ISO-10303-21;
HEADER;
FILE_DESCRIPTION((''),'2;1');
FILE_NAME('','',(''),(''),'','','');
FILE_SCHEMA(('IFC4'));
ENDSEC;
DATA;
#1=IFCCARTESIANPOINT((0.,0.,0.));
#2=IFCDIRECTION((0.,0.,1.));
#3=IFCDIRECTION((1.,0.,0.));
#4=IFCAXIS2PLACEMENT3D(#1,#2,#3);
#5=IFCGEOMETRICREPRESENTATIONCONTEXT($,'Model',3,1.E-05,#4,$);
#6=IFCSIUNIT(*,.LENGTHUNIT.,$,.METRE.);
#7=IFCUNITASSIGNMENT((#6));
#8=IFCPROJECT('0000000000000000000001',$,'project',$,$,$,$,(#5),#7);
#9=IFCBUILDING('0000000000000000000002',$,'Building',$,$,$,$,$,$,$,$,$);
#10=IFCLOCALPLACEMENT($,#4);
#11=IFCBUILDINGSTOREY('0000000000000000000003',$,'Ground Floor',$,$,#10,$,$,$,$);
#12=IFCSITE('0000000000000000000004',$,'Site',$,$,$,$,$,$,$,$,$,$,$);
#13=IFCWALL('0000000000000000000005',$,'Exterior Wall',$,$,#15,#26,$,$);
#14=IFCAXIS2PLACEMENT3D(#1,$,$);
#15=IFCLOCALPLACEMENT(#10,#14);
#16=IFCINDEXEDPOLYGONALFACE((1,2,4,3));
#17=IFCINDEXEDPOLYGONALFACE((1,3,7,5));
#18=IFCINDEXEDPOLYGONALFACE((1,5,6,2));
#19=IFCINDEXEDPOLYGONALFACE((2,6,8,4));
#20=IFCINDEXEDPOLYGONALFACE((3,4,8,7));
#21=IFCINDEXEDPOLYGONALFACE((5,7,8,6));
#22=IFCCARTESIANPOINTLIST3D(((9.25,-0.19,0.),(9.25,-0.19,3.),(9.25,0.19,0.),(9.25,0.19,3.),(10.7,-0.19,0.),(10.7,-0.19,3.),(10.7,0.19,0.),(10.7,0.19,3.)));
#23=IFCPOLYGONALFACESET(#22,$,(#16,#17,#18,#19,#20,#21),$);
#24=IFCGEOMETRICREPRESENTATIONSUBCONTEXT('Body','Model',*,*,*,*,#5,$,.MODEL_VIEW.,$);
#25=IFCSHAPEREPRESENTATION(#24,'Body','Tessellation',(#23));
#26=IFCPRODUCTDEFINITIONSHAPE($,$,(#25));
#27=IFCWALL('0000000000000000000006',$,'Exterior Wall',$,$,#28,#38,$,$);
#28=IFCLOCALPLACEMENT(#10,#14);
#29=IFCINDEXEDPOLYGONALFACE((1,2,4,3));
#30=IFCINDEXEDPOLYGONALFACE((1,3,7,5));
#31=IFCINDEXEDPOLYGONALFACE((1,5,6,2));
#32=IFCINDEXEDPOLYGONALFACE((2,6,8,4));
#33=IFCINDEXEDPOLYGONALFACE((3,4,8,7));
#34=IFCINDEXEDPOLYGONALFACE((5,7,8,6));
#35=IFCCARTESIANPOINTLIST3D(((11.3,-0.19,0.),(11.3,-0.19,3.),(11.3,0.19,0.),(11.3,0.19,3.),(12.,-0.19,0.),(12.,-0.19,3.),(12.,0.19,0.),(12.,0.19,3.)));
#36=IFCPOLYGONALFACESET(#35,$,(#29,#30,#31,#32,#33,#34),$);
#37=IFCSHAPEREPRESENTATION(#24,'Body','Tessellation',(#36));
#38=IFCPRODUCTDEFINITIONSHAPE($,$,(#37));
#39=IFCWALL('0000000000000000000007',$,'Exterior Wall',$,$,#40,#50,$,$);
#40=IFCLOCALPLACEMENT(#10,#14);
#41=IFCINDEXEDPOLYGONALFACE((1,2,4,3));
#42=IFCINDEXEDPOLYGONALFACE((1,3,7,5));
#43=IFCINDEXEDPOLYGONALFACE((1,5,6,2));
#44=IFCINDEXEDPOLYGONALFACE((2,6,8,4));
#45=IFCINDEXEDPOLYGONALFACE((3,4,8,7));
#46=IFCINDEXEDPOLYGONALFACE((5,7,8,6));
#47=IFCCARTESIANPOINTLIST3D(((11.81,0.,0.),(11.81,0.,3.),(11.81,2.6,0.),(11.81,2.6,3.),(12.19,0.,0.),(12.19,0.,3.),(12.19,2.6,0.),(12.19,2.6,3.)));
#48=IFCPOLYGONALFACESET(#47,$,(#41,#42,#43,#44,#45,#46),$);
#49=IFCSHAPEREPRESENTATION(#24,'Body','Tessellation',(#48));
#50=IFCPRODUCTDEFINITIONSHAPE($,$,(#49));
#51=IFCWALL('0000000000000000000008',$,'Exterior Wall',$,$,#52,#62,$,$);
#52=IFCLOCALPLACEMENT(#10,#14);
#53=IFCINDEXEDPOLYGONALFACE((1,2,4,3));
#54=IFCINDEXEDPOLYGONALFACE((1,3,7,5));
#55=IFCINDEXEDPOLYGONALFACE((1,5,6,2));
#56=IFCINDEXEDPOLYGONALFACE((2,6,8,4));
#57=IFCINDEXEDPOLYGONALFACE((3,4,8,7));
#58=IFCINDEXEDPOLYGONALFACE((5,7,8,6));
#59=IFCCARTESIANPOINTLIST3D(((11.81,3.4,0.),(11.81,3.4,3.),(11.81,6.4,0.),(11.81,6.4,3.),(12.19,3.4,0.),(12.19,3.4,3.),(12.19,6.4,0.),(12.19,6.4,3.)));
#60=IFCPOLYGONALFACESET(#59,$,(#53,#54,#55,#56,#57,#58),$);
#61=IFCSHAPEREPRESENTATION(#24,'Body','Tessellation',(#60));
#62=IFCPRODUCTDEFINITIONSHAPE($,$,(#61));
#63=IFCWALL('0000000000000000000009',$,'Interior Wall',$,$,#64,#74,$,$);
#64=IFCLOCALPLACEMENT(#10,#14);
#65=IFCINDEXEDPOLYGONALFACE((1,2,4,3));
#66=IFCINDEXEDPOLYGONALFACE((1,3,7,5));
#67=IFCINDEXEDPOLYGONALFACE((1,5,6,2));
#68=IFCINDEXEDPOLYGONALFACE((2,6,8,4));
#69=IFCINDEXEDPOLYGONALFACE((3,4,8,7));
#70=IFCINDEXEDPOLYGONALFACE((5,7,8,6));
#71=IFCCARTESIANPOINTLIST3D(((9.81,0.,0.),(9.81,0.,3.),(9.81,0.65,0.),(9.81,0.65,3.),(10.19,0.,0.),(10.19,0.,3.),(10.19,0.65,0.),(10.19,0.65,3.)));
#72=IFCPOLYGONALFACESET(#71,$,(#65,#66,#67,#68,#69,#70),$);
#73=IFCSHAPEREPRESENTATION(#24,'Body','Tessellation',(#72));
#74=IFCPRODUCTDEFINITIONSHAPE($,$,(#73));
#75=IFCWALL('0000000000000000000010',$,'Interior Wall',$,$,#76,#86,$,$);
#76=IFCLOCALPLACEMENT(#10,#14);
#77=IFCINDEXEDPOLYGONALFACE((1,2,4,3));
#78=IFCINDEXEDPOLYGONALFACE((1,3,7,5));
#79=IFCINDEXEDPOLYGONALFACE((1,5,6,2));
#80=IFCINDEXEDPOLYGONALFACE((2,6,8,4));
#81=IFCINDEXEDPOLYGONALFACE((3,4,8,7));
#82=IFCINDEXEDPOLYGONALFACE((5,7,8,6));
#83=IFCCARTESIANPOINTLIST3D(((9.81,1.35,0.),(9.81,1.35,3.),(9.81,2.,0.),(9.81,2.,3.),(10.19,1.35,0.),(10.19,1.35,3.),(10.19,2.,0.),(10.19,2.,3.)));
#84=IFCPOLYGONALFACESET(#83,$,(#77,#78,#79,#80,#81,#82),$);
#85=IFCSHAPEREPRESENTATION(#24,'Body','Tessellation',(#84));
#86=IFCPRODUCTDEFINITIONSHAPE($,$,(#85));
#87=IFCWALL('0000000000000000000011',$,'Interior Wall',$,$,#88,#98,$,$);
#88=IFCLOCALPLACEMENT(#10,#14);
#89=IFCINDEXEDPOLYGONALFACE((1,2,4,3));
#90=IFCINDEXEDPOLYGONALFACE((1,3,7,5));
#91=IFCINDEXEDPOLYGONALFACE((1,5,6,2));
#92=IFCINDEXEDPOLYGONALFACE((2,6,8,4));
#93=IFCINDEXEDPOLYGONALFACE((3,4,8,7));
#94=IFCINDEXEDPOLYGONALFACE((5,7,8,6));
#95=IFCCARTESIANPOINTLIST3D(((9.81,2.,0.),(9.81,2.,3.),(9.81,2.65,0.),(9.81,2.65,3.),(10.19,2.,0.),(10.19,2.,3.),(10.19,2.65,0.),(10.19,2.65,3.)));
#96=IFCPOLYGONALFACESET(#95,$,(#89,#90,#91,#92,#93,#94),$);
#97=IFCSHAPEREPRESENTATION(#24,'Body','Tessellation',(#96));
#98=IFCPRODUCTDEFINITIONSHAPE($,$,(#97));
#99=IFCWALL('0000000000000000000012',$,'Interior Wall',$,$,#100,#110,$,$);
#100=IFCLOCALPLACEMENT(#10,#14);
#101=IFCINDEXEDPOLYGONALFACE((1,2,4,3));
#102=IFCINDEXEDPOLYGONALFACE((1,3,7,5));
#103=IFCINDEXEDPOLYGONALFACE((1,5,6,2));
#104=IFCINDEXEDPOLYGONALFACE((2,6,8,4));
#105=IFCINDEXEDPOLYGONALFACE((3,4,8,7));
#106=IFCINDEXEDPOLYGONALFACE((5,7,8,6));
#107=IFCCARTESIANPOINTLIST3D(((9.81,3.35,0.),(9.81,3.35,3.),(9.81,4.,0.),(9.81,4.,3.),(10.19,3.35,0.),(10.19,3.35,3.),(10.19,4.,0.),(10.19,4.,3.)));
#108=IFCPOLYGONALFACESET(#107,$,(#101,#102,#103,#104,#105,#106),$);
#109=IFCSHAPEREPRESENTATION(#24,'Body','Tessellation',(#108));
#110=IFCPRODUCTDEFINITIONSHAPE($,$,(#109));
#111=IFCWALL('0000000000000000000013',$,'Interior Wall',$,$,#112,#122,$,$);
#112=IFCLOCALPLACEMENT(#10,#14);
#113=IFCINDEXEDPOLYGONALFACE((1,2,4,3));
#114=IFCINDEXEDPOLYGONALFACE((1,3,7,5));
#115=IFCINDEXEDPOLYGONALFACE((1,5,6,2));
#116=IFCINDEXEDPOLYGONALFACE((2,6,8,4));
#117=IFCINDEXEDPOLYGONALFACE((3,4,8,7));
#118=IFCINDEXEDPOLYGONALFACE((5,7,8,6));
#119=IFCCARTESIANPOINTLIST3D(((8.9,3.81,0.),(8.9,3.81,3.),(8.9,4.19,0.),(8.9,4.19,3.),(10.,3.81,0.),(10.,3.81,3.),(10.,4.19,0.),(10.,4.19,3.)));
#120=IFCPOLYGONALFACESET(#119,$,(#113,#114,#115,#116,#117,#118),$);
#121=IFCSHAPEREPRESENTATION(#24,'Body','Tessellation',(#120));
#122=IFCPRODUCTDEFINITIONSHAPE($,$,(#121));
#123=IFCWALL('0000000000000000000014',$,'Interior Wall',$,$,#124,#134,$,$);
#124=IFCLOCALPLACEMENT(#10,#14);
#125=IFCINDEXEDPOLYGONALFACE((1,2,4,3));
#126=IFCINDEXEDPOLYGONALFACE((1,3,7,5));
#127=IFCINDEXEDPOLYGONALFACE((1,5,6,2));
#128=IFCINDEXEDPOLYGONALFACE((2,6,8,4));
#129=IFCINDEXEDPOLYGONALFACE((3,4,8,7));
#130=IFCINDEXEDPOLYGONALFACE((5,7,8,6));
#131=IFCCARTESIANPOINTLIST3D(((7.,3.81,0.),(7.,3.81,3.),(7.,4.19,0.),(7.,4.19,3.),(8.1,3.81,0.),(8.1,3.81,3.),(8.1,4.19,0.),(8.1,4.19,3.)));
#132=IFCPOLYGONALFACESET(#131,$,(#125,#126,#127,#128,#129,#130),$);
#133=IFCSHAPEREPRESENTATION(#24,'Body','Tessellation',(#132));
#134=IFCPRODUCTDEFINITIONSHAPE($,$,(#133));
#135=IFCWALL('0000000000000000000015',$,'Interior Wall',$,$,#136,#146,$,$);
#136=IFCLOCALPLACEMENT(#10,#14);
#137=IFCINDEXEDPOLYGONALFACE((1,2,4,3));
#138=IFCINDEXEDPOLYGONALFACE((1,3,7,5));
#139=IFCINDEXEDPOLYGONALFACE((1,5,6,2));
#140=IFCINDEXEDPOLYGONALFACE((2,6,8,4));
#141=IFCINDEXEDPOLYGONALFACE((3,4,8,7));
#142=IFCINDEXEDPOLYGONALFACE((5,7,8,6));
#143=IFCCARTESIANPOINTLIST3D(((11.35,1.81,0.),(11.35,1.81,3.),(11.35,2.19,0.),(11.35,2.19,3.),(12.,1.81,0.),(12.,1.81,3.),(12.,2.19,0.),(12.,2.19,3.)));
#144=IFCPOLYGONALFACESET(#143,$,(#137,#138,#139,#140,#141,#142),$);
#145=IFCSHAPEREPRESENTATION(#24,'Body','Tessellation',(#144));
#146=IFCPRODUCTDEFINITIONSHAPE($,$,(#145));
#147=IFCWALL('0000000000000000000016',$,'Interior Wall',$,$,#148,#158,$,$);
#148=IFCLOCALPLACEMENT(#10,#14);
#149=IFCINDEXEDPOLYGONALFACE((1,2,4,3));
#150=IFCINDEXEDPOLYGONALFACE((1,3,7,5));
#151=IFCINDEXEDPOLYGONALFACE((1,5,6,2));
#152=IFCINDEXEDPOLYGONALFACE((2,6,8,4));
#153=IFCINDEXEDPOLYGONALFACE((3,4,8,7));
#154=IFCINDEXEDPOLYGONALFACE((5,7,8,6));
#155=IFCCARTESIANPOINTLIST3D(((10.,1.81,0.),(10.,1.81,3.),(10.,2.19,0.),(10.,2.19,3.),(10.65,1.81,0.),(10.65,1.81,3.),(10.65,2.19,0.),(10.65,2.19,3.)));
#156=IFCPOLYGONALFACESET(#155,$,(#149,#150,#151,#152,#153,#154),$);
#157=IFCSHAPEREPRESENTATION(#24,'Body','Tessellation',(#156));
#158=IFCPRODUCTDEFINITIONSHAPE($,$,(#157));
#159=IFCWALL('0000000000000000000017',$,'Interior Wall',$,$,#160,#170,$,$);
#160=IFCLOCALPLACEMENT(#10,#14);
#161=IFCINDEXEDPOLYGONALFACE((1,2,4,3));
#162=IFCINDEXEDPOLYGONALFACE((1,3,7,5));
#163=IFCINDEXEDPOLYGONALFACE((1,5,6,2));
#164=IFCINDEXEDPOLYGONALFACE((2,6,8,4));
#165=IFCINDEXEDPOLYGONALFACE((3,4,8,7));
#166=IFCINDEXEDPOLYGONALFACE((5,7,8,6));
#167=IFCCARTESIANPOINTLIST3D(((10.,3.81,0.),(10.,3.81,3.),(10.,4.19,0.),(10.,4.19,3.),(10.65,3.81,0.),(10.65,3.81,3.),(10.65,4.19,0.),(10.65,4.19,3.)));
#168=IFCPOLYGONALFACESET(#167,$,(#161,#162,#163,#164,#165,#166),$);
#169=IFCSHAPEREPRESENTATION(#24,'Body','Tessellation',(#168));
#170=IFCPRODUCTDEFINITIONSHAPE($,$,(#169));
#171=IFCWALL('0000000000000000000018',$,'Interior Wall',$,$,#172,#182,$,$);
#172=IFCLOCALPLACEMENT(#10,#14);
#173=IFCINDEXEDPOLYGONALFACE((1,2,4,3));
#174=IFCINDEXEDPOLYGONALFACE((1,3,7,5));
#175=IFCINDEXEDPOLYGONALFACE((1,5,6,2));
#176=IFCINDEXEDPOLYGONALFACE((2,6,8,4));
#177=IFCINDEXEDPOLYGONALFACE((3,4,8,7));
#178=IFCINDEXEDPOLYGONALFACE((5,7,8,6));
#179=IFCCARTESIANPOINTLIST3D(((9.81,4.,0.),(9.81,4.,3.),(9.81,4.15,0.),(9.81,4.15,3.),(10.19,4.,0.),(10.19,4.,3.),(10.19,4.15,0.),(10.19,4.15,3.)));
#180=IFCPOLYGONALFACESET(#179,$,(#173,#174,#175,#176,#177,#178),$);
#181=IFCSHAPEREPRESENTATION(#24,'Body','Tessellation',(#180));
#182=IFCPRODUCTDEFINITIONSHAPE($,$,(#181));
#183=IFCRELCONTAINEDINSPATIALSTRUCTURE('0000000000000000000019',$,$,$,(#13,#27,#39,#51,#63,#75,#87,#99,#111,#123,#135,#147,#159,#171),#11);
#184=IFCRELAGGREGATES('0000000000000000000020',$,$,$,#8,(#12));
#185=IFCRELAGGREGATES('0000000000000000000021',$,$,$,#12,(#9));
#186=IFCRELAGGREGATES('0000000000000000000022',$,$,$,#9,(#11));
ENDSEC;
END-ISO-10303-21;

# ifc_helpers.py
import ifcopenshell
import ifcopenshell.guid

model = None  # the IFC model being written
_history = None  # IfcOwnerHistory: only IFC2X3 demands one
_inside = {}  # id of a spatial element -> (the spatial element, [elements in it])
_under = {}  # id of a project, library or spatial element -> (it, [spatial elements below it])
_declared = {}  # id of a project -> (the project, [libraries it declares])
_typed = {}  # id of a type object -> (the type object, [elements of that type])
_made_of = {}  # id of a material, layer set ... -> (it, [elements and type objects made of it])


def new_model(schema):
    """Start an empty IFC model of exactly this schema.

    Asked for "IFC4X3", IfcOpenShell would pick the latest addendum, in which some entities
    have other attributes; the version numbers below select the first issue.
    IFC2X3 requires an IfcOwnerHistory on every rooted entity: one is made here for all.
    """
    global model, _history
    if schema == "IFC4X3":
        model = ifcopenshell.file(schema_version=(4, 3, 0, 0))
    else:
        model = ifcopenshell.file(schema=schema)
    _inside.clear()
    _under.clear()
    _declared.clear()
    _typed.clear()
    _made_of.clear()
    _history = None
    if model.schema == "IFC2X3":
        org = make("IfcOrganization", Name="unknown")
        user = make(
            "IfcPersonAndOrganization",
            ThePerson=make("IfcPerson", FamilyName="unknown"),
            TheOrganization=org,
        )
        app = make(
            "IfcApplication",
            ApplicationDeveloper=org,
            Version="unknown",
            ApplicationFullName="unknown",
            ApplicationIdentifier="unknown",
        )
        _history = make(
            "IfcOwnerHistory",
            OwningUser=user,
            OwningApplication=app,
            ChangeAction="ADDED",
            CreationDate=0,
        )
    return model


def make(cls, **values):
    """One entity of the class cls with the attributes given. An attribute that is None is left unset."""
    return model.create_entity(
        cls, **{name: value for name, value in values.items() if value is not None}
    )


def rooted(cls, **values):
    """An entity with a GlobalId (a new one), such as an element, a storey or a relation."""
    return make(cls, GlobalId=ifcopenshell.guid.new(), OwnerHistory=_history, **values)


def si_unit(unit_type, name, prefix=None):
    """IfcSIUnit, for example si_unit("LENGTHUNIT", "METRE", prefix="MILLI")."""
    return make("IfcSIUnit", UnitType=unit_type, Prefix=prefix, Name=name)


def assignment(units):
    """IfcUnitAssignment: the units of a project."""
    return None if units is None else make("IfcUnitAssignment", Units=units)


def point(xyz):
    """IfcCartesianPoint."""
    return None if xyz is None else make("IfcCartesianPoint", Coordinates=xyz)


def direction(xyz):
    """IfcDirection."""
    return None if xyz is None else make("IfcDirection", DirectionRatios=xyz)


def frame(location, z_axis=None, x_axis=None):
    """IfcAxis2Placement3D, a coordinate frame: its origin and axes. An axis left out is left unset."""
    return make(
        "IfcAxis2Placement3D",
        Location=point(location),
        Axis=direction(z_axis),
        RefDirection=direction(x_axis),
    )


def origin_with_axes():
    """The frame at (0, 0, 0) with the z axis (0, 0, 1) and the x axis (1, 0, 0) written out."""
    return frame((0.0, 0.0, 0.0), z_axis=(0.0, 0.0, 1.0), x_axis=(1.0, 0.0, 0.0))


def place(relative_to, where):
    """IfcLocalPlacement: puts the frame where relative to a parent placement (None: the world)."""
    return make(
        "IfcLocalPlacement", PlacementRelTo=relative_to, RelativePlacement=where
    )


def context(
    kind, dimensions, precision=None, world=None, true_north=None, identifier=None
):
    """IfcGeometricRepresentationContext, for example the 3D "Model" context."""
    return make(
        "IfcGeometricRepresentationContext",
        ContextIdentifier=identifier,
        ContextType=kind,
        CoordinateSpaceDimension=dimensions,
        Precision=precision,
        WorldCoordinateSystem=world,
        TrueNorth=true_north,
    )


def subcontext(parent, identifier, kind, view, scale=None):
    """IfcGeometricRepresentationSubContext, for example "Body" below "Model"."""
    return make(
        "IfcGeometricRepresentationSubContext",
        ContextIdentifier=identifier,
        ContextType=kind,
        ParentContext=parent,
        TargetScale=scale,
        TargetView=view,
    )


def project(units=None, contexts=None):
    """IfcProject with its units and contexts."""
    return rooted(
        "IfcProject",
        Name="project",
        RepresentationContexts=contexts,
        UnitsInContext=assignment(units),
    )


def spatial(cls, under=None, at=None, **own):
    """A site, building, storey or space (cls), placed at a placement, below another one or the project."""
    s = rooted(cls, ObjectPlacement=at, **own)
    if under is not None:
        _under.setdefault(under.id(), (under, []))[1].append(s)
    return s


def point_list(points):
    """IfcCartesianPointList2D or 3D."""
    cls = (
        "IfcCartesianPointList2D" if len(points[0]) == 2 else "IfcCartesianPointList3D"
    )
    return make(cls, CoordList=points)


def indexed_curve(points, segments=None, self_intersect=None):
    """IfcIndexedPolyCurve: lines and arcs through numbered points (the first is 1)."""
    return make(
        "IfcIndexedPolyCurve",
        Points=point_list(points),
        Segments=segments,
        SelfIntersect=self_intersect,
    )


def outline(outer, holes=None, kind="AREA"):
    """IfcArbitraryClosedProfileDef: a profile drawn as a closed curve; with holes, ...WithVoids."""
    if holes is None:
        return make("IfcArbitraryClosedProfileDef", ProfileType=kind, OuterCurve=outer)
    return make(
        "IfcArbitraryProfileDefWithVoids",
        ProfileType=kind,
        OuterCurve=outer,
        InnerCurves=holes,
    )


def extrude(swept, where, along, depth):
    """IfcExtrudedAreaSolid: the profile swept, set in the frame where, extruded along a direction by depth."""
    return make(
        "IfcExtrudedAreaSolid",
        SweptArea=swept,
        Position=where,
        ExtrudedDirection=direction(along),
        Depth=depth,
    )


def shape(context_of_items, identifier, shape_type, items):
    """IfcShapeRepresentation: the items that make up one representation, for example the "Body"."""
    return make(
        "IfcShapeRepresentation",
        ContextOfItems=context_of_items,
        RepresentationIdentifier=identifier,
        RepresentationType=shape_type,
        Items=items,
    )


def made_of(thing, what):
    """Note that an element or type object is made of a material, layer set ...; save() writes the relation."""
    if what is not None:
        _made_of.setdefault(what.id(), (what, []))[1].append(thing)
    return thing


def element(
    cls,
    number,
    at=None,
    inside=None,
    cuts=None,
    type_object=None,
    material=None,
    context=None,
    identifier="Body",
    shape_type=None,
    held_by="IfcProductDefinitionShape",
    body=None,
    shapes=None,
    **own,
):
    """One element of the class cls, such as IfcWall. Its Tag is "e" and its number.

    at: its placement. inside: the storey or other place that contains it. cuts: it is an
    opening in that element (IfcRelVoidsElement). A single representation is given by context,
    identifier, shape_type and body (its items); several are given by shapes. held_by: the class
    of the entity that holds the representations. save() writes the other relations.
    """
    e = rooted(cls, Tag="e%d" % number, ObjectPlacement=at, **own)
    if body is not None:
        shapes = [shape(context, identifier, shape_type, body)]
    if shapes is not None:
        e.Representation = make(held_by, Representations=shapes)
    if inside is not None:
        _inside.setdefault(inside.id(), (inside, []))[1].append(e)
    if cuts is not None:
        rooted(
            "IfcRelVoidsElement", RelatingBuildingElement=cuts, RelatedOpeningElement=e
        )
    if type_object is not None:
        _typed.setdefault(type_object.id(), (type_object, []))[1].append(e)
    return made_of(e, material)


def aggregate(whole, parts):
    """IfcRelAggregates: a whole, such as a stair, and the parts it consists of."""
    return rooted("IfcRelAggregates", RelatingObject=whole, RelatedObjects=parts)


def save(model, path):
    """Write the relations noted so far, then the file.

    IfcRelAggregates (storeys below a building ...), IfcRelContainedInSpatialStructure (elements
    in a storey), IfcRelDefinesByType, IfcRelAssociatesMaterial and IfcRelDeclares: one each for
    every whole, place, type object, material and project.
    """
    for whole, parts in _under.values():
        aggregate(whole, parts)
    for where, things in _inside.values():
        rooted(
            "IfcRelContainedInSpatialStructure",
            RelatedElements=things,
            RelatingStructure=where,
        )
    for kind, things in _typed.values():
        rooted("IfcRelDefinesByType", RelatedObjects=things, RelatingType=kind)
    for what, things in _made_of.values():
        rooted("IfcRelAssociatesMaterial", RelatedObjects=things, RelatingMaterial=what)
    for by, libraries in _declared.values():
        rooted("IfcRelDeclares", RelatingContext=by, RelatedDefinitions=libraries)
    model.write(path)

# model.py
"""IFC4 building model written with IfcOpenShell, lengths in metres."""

from ifc_helpers import new_model, si_unit, frame, origin_with_axes, place, context, subcontext, project, spatial, indexed_curve, outline, extrude, element, save


model = new_model("IFC4")

# Units and contexts
model_context = context("Model", 3, precision=1e-05, world=origin_with_axes())
body_context = subcontext(model_context, "Body", "Model", "MODEL_VIEW")
ifc_project = project(units=[si_unit("LENGTHUNIT", "METRE")], contexts=[model_context])

# Site, building, storey
site = spatial("IfcSite", under=ifc_project, Name="Site")
building = spatial("IfcBuilding", under=site, Name="Building")
storey_placement = place(None, origin_with_axes())
storey = spatial("IfcBuildingStorey", under=building, at=storey_placement, Name="Ground Floor")

# Walls
wall_1_placement = place(storey_placement, frame((9.25, 0.0, 0.0), z_axis=(0.0, 0.0, 1.0), x_axis=(1.0, 0.0, 0.0)))
element("IfcWall", 1, at=wall_1_placement, inside=storey, Name="Exterior Wall", context=body_context, shape_type="SweptSolid", body=[
    extrude(outline(indexed_curve([(0.0, 0.0), (0.0, 0.38), (1.45, 0.38), (1.45, 0.0), (0.0, 0.0)], self_intersect=False)), frame((0.0, -0.19, 0.0), z_axis=(0.0, 0.0, 1.0), x_axis=(1.0, 0.0, 0.0)), (0.0, 0.0, 1.0), 3.0),
])
wall_2_placement = place(storey_placement, frame((11.3, 0.0, 0.0), z_axis=(0.0, 0.0, 1.0), x_axis=(1.0, 0.0, 0.0)))
element("IfcWall", 2, at=wall_2_placement, inside=storey, Name="Exterior Wall", context=body_context, shape_type="SweptSolid", body=[
    extrude(outline(indexed_curve([(0.0, 0.0), (0.0, 0.38), (0.7, 0.38), (0.7, 0.0), (0.0, 0.0)], self_intersect=False)), frame((0.0, -0.19, 0.0), z_axis=(0.0, 0.0, 1.0), x_axis=(1.0, 0.0, 0.0)), (0.0, 0.0, 1.0), 3.0),
])
wall_3_placement = place(storey_placement, frame((12.0, 0.0, 0.0), z_axis=(0.0, 0.0, 1.0), x_axis=(0.0, 1.0, 0.0)))
element("IfcWall", 3, at=wall_3_placement, inside=storey, Name="Exterior Wall", context=body_context, shape_type="SweptSolid", body=[
    extrude(outline(indexed_curve([(0.0, 0.0), (0.0, 0.38), (2.6, 0.38), (2.6, 0.0), (0.0, 0.0)], self_intersect=False)), frame((0.0, -0.19, 0.0), z_axis=(0.0, 0.0, 1.0), x_axis=(1.0, 0.0, 0.0)), (0.0, 0.0, 1.0), 3.0),
])
wall_4_placement = place(storey_placement, frame((12.0, 3.4, 0.0), z_axis=(0.0, 0.0, 1.0), x_axis=(0.0, 1.0, 0.0)))
element("IfcWall", 4, at=wall_4_placement, inside=storey, Name="Exterior Wall", context=body_context, shape_type="SweptSolid", body=[
    extrude(outline(indexed_curve([(0.0, 0.0), (0.0, 0.38), (3.0, 0.38), (3.0, 0.0), (0.0, 0.0)], self_intersect=False)), frame((0.0, -0.19, 0.0), z_axis=(0.0, 0.0, 1.0), x_axis=(1.0, 0.0, 0.0)), (0.0, 0.0, 1.0), 3.0),
])
wall_5_placement = place(storey_placement, frame((10.0, 0.0, 0.0), z_axis=(0.0, 0.0, 1.0), x_axis=(0.0, 1.0, 0.0)))
element("IfcWall", 5, at=wall_5_placement, inside=storey, Name="Interior Wall", context=body_context, shape_type="SweptSolid", body=[
    extrude(outline(indexed_curve([(0.0, 0.0), (0.0, 0.38), (0.65, 0.38), (0.65, 0.0), (0.0, 0.0)], self_intersect=False)), frame((0.0, -0.19, 0.0), z_axis=(0.0, 0.0, 1.0), x_axis=(1.0, 0.0, 0.0)), (0.0, 0.0, 1.0), 3.0),
])
for number, where, z_axis, x_axis, name in (
    (6, (10.0, 1.35, 0.0), (0.0, 0.0, 1.0), (0.0, 1.0, 0.0), "Interior Wall"),
    (7, (10.0, 2.0, 0.0), (0.0, 0.0, 1.0), (0.0, 1.0, 0.0), "Interior Wall"),
    (8, (10.0, 3.35, 0.0), (0.0, 0.0, 1.0), (0.0, 1.0, 0.0), "Interior Wall"),
):
    element("IfcWall", number, at=place(storey_placement, frame(where, z_axis=z_axis, x_axis=x_axis)), inside=storey, Name=name, context=body_context, shape_type="SweptSolid", body=[
        extrude(outline(indexed_curve([(0.0, 0.0), (0.0, 0.38), (0.65, 0.38), (0.65, 0.0), (0.0, 0.0)], self_intersect=False)), frame((0.0, -0.19, 0.0), z_axis=(0.0, 0.0, 1.0), x_axis=(1.0, 0.0, 0.0)), (0.0, 0.0, 1.0), 3.0),
    ])
for number, where, z_axis, x_axis, name in (
    (9, (10.0, 4.0, 0.0), (0.0, 0.0, 1.0), (-1.0, 0.0, 0.0), "Interior Wall"),
    (10, (8.1, 4.0, 0.0), (0.0, 0.0, 1.0), (-1.0, 0.0, 0.0), "Interior Wall"),
):
    element("IfcWall", number, at=place(storey_placement, frame(where, z_axis=z_axis, x_axis=x_axis)), inside=storey, Name=name, context=body_context, shape_type="SweptSolid", body=[
        extrude(outline(indexed_curve([(0.0, 0.0), (0.0, 0.38), (1.1, 0.38), (1.1, 0.0), (0.0, 0.0)], self_intersect=False)), frame((0.0, -0.19, 0.0), z_axis=(0.0, 0.0, 1.0), x_axis=(1.0, 0.0, 0.0)), (0.0, 0.0, 1.0), 3.0),
    ])
for number, where, z_axis, x_axis, name in (
    (11, (12.0, 2.0, 0.0), (0.0, 0.0, 1.0), (-1.0, 0.0, 0.0), "Interior Wall"),
    (12, (10.65, 2.0, 0.0), (0.0, 0.0, 1.0), (-1.0, 0.0, 0.0), "Interior Wall"),
    (13, (10.65, 4.0, 0.0), (0.0, 0.0, 1.0), (-1.0, 0.0, 0.0), "Interior Wall"),
):
    element("IfcWall", number, at=place(storey_placement, frame(where, z_axis=z_axis, x_axis=x_axis)), inside=storey, Name=name, context=body_context, shape_type="SweptSolid", body=[
        extrude(outline(indexed_curve([(0.0, 0.0), (0.0, 0.38), (0.65, 0.38), (0.65, 0.0), (0.0, 0.0)], self_intersect=False)), frame((0.0, -0.19, 0.0), z_axis=(0.0, 0.0, 1.0), x_axis=(1.0, 0.0, 0.0)), (0.0, 0.0, 1.0), 3.0),
    ])
wall_6_placement = place(storey_placement, frame((10.0, 4.0, 0.0), z_axis=(0.0, 0.0, 1.0), x_axis=(0.0, 1.0, 0.0)))
element("IfcWall", 14, at=wall_6_placement, inside=storey, Name="Interior Wall", context=body_context, shape_type="SweptSolid", body=[
    extrude(outline(indexed_curve([(0.0, 0.0), (0.0, 0.38), (0.15, 0.38), (0.15, 0.0), (0.0, 0.0)], self_intersect=False)), frame((0.0, -0.19, 0.0), z_axis=(0.0, 0.0, 1.0), x_axis=(1.0, 0.0, 0.0)), (0.0, 0.0, 1.0), 3.0),
])

save(model, "model.ifc")
